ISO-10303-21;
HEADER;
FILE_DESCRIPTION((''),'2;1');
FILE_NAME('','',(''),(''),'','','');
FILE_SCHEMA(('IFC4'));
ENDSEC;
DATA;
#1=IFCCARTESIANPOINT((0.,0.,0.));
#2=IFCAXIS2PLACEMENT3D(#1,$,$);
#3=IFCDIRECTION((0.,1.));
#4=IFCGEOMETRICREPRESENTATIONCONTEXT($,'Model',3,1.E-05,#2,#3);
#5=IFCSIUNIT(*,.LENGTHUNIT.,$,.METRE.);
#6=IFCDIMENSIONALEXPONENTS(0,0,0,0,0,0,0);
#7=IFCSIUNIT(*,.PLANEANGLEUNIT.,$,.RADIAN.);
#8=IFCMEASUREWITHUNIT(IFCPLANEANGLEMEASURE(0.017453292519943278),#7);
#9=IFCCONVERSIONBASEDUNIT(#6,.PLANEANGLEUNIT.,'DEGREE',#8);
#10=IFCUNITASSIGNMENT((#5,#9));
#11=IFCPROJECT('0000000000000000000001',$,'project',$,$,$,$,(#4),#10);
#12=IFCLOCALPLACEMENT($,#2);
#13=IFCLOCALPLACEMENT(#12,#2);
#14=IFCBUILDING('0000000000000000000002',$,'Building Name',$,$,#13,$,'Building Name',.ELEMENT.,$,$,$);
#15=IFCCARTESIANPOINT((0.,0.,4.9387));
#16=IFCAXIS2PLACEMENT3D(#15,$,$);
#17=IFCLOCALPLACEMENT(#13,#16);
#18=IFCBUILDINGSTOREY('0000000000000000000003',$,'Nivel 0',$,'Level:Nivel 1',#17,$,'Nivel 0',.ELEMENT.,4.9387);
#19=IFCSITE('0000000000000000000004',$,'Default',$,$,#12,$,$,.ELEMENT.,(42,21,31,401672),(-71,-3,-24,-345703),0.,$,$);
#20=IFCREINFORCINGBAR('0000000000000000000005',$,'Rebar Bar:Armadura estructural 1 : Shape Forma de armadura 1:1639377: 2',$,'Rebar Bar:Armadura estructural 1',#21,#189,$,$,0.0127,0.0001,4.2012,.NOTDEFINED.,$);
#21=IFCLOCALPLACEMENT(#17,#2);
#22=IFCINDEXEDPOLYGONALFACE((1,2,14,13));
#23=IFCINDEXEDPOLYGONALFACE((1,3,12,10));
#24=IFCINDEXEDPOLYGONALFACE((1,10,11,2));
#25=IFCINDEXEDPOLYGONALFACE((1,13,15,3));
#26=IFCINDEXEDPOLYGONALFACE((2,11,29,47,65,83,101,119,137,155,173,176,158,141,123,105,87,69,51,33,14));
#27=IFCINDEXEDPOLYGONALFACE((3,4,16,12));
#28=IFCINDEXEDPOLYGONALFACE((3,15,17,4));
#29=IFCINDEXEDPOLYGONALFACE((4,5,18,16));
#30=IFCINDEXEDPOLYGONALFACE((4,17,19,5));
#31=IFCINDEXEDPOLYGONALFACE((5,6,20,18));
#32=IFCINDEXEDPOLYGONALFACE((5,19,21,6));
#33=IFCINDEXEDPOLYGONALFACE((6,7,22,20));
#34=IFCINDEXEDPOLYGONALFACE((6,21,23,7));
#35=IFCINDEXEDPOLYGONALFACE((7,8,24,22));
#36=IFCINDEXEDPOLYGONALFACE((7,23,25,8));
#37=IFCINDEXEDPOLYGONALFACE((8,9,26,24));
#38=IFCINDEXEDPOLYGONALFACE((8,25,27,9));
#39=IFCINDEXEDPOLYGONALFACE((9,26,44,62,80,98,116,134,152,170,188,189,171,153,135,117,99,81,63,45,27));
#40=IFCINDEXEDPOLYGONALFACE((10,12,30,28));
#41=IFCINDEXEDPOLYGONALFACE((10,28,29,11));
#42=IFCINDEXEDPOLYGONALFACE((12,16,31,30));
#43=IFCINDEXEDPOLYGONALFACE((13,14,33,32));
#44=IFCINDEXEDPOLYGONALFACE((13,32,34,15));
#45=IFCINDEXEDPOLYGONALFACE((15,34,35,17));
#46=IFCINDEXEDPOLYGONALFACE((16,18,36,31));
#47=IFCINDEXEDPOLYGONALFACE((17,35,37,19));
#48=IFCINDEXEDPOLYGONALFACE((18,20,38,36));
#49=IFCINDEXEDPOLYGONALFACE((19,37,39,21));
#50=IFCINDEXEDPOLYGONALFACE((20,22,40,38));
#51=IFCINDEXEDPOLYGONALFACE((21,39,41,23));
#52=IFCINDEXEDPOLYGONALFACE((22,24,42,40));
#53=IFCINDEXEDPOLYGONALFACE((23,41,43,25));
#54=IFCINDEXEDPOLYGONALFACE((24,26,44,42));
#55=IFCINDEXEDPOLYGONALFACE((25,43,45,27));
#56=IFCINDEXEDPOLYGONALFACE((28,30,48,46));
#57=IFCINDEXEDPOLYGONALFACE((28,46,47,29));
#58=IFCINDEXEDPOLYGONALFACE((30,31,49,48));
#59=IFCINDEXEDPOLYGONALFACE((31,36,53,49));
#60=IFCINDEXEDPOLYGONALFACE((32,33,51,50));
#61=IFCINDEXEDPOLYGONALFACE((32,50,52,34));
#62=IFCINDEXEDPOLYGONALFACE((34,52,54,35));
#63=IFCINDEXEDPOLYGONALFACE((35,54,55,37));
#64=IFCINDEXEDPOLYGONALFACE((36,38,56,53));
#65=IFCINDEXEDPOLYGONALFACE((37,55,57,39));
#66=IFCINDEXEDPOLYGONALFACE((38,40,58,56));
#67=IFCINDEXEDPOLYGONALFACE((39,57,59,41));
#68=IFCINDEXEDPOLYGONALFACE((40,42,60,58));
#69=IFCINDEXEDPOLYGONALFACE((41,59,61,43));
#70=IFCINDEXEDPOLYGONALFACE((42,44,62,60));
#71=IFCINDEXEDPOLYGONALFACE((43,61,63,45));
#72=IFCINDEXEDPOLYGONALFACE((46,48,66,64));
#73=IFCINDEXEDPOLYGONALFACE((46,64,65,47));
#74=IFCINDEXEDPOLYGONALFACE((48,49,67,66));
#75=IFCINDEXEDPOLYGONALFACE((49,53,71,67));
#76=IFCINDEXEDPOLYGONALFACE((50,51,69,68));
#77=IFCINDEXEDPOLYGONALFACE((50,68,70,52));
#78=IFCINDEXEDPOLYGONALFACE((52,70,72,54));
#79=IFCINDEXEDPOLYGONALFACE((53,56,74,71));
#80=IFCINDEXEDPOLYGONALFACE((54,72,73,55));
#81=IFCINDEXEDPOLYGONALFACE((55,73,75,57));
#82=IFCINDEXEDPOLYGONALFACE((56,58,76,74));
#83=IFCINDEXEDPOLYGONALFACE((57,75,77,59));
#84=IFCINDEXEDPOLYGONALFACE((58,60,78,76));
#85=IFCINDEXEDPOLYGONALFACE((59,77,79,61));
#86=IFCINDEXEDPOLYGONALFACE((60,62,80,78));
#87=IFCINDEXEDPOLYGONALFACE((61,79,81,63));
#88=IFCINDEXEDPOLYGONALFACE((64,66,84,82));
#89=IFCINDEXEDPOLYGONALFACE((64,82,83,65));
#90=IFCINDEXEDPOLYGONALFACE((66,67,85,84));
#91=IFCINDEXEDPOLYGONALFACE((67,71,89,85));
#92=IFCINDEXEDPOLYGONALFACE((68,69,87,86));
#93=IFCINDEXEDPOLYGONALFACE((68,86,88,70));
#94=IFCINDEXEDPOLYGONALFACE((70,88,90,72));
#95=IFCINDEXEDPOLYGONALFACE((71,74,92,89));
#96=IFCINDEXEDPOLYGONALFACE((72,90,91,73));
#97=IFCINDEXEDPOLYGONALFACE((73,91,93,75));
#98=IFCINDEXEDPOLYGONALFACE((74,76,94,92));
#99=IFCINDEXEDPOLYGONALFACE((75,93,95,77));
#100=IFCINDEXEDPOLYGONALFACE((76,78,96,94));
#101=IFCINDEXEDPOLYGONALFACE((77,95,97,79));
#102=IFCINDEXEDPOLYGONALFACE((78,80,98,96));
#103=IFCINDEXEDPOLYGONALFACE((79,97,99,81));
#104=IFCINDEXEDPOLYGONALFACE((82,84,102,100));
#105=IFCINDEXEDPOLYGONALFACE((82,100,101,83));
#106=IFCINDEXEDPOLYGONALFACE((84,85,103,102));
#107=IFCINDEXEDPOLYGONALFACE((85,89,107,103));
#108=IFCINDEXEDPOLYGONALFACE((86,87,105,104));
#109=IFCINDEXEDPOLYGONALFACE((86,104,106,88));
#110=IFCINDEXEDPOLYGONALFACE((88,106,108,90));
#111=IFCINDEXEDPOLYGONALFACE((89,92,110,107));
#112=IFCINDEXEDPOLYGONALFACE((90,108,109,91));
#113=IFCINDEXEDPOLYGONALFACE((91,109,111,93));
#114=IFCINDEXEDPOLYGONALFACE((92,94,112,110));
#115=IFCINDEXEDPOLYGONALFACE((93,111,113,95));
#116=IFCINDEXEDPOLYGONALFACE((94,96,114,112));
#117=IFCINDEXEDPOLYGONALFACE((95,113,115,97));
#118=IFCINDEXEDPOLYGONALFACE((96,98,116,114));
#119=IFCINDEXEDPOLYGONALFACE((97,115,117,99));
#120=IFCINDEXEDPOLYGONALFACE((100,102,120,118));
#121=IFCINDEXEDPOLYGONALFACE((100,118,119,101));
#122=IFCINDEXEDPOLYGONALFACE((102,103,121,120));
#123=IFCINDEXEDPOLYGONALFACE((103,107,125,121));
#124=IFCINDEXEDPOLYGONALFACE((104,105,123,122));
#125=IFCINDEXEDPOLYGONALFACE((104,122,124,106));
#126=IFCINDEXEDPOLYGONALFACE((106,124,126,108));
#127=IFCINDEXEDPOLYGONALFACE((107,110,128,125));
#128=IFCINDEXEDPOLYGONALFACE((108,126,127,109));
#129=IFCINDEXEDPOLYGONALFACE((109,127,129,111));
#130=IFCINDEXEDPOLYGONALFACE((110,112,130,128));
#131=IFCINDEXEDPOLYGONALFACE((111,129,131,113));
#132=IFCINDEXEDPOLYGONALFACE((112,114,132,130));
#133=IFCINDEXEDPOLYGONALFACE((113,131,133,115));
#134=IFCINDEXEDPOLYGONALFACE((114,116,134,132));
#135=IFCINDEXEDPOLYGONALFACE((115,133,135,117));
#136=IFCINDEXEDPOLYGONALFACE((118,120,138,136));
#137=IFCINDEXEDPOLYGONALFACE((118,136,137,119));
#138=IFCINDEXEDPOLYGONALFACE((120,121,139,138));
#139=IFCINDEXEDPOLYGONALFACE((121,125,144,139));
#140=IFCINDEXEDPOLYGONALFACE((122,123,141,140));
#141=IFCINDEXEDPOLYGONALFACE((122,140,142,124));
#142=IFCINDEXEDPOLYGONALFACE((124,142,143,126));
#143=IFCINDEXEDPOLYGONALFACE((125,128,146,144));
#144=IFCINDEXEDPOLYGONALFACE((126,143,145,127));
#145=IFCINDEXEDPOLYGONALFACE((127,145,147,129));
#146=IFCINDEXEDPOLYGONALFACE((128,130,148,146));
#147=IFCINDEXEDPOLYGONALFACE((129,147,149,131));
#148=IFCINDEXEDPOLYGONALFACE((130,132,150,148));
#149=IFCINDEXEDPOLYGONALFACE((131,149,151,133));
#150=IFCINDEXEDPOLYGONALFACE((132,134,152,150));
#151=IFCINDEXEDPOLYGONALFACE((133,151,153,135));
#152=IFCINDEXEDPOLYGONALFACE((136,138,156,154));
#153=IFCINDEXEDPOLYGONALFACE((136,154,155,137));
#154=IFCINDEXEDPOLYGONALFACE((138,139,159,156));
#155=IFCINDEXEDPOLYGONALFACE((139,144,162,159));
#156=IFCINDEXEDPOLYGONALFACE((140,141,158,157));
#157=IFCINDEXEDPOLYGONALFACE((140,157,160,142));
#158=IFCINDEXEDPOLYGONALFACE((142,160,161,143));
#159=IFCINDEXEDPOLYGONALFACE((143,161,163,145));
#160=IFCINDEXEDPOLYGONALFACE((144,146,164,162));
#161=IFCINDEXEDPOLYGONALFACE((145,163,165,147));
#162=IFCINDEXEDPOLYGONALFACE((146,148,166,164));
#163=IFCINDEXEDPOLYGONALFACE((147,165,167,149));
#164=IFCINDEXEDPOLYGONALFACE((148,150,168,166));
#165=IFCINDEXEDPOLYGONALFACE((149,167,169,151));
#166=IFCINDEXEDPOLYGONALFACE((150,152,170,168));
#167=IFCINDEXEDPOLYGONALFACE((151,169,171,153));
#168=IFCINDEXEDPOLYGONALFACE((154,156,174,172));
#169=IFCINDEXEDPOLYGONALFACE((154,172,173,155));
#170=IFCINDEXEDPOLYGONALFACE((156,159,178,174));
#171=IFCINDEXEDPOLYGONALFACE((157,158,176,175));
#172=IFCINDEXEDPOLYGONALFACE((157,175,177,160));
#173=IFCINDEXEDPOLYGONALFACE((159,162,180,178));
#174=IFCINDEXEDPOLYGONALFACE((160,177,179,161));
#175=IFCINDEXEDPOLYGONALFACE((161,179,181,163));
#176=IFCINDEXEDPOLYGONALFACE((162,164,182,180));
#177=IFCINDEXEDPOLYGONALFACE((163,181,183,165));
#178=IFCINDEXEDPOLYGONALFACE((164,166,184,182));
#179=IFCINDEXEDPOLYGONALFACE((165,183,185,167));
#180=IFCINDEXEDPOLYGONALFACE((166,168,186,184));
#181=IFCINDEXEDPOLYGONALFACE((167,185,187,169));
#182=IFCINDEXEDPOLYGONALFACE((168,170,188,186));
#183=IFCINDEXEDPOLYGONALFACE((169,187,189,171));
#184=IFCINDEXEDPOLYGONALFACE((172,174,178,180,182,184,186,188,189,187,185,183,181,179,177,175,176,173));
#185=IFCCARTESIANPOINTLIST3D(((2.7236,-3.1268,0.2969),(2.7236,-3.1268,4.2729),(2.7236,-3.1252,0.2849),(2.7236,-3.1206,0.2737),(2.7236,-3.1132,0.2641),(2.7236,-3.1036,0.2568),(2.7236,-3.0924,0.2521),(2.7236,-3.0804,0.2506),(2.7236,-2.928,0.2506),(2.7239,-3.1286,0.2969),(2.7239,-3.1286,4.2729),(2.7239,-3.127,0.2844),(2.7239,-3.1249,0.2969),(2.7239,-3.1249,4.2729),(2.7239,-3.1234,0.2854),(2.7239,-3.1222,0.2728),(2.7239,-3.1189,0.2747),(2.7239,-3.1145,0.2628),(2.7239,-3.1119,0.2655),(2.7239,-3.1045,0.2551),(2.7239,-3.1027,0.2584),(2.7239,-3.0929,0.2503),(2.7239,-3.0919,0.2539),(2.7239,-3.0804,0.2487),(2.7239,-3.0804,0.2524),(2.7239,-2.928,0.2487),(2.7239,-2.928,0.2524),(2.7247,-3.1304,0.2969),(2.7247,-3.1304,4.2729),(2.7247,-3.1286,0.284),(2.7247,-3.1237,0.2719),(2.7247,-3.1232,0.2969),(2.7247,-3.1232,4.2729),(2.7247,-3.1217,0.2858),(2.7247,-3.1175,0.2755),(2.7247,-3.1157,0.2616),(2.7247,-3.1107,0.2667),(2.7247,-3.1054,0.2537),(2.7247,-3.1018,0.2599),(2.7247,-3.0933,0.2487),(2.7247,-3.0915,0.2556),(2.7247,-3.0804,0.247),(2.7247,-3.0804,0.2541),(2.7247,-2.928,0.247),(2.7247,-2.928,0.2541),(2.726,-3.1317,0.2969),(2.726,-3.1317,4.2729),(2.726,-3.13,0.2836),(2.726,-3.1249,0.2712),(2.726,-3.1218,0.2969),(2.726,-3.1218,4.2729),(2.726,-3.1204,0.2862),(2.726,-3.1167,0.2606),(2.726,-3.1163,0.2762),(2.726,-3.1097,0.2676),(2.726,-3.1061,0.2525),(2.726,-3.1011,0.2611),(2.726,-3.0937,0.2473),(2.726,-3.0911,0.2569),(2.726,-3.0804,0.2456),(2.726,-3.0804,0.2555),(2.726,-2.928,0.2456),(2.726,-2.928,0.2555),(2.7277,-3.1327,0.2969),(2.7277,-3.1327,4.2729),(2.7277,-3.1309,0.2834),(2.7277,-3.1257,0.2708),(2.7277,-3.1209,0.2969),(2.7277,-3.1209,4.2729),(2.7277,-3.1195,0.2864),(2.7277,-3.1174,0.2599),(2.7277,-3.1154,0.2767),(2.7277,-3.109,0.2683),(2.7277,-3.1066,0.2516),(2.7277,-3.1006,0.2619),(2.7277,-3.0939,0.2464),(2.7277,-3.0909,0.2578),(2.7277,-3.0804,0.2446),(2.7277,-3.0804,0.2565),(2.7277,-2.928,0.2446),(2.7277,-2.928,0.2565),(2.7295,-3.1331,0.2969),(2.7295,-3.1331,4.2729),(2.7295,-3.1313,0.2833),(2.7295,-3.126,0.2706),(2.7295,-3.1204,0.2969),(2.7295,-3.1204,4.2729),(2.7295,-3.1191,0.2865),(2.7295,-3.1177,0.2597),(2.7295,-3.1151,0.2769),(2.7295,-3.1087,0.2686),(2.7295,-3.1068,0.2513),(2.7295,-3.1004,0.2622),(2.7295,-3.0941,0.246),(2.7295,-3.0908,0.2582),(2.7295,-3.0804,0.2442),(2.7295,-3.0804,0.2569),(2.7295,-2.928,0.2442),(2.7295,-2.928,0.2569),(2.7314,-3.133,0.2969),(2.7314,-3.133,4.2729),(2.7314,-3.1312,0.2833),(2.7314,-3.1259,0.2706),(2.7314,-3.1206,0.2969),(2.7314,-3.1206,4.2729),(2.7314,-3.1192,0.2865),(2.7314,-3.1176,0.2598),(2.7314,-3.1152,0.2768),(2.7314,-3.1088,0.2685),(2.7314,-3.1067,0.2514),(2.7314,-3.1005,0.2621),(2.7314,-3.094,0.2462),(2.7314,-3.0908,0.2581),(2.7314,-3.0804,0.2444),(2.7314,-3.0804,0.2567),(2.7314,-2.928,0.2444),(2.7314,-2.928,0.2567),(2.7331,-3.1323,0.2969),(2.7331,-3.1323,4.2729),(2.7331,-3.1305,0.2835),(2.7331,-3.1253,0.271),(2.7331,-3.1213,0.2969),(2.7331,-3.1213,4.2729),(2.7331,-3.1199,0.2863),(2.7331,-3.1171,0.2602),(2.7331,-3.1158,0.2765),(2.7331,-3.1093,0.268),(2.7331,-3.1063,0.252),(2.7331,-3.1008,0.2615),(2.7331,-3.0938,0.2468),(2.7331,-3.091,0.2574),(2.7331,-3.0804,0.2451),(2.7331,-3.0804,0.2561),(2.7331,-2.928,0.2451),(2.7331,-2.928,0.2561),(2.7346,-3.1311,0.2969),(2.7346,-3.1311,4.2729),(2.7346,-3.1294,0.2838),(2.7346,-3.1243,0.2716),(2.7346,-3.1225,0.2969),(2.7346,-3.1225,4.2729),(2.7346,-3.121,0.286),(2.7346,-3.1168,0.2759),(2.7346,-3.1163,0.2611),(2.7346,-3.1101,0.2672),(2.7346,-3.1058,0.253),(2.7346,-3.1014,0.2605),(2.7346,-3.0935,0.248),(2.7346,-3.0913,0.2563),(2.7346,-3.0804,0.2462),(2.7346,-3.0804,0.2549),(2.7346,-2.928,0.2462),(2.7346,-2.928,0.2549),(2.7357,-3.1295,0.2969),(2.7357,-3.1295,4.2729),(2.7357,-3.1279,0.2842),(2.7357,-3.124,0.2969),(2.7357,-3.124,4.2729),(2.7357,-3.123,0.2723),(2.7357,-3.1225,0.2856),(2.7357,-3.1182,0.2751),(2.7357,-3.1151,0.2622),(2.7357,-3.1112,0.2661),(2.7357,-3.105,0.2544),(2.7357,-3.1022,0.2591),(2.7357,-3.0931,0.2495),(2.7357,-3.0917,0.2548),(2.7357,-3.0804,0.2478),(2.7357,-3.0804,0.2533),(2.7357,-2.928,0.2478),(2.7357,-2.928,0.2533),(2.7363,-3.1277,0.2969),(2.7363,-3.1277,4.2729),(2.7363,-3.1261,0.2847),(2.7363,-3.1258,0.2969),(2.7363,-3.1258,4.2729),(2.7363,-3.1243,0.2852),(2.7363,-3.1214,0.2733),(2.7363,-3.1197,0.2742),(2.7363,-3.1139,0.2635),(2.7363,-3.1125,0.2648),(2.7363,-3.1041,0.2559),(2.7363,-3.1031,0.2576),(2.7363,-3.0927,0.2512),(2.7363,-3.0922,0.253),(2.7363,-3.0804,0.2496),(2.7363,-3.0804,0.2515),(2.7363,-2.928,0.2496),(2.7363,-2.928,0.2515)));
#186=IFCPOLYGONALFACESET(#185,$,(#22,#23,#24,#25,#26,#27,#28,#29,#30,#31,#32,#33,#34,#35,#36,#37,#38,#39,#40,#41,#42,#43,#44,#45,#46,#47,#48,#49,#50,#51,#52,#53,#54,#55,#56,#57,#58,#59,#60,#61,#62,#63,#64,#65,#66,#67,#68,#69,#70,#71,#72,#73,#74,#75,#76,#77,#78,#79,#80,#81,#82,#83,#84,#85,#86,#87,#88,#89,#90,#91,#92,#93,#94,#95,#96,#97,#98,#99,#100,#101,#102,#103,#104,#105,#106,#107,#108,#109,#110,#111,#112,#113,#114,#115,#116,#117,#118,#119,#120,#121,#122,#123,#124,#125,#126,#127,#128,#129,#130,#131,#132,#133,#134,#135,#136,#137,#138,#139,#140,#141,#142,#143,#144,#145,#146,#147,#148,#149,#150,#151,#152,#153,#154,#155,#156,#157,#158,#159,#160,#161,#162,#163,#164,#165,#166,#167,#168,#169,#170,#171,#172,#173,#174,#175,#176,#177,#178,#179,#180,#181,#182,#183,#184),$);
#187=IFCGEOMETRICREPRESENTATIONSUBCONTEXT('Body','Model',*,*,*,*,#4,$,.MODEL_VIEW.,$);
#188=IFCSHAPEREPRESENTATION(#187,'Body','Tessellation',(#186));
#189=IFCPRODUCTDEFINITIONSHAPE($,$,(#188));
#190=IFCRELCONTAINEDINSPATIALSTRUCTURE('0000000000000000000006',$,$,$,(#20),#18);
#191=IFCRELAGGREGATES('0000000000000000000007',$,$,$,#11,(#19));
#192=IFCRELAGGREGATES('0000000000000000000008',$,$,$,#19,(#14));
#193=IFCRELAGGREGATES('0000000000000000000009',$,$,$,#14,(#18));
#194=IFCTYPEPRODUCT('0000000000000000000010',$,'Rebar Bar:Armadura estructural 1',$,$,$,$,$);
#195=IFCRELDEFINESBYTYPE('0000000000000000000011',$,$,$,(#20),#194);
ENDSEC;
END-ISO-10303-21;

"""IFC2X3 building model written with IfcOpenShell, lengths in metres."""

from ifc_helpers import new_model, entity, si_unit, converted_unit, direction, frame, origin, place, context, subcontext, project, spatial, type_object, element, save


model = new_model("IFC2X3")

# Units and contexts
model_context = context("Model", 3, precision=1e-05, world=origin(), true_north=direction((0.0, 1.0)))
body_context = subcontext(model_context, "Body", "Model", "MODEL_VIEW")
ifc_project = project(units=[si_unit("LENGTHUNIT", "METRE"), converted_unit("PLANEANGLEUNIT", "DEGREE", entity("IfcPlaneAngleMeasure", 0.017453292519943278), si_unit("PLANEANGLEUNIT", "RADIAN"), dimensions=[0, 0, 0, 0, 0, 0, 0])], contexts=[model_context])

# Site, building, storey
site_placement = place(None, origin())
site = spatial("IfcSite", under=ifc_project, at=site_placement, Name="Default", CompositionType="ELEMENT", RefLatitude=(42, 21, 31, 401672), RefLongitude=(-71, -3, -24, -345703), RefElevation=0.0)
building_placement = place(site_placement, origin())
building = spatial("IfcBuilding", under=site, at=building_placement, Name="Building Name", LongName="Building Name", CompositionType="ELEMENT")
storey_placement = place(building_placement, frame((0.0, 0.0, 4.9387)))
storey = spatial("IfcBuildingStorey", under=building, at=storey_placement, Name="Nivel 0", ObjectType="Level:Nivel 1", LongName="Nivel 0", CompositionType="ELEMENT", Elevation=4.9387)

# Reinforcing bar
type_product = type_object("IfcTypeProduct", Name="Rebar Bar:Armadura estructural 1")
reinforcing_bar_1_placement = place(storey_placement, origin())
element("IfcReinforcingBar", 1, at=reinforcing_bar_1_placement, inside=storey, type_object=type_product, Name="Rebar Bar:Armadura estructural 1 : Shape Forma de armadura 1:1639377: 2", ObjectType="Rebar Bar:Armadura estructural 1", BarLength=4.2012, BarRole="NOTDEFINED", CrossSectionArea=0.0001, NominalDiameter=0.0127, context=body_context, shape_type="AdvancedSweptSolid", body=[
    entity("IfcSweptDiskSolid", entity("IfcCompositeCurve", [entity("IfcCompositeCurveSegment", "CONTINUOUS", True, entity("IfcPolyline", [entity("IfcCartesianPoint", [2.73, -2.928, 0.2506]), entity("IfcCartesianPoint", [2.73, -3.0804, 0.2506])])), entity("IfcCompositeCurveSegment", "CONTINUOUS", True, entity("IfcTrimmedCurve", entity("IfcCircle", entity("IfcAxis2Placement3D", entity("IfcCartesianPoint", [2.73, -3.0804, 0.2969]), entity("IfcDirection", [-1.0, 0.0, 0.0]), entity("IfcDirection", [0.0, -1.0, 0.0])), 0.0464), [entity("IfcParameterValue", 270.0)], [entity("IfcParameterValue", 360.0)], True, "PARAMETER")), entity("IfcCompositeCurveSegment", "CONTINUOUS", True, entity("IfcPolyline", [entity("IfcCartesianPoint", [2.73, -3.1268, 0.2969]), entity("IfcCartesianPoint", [2.73, -3.1268, 4.2729])]))], False), 0.0063, None, 0.0, 92.0),
])

save(model, "model.ifc")
